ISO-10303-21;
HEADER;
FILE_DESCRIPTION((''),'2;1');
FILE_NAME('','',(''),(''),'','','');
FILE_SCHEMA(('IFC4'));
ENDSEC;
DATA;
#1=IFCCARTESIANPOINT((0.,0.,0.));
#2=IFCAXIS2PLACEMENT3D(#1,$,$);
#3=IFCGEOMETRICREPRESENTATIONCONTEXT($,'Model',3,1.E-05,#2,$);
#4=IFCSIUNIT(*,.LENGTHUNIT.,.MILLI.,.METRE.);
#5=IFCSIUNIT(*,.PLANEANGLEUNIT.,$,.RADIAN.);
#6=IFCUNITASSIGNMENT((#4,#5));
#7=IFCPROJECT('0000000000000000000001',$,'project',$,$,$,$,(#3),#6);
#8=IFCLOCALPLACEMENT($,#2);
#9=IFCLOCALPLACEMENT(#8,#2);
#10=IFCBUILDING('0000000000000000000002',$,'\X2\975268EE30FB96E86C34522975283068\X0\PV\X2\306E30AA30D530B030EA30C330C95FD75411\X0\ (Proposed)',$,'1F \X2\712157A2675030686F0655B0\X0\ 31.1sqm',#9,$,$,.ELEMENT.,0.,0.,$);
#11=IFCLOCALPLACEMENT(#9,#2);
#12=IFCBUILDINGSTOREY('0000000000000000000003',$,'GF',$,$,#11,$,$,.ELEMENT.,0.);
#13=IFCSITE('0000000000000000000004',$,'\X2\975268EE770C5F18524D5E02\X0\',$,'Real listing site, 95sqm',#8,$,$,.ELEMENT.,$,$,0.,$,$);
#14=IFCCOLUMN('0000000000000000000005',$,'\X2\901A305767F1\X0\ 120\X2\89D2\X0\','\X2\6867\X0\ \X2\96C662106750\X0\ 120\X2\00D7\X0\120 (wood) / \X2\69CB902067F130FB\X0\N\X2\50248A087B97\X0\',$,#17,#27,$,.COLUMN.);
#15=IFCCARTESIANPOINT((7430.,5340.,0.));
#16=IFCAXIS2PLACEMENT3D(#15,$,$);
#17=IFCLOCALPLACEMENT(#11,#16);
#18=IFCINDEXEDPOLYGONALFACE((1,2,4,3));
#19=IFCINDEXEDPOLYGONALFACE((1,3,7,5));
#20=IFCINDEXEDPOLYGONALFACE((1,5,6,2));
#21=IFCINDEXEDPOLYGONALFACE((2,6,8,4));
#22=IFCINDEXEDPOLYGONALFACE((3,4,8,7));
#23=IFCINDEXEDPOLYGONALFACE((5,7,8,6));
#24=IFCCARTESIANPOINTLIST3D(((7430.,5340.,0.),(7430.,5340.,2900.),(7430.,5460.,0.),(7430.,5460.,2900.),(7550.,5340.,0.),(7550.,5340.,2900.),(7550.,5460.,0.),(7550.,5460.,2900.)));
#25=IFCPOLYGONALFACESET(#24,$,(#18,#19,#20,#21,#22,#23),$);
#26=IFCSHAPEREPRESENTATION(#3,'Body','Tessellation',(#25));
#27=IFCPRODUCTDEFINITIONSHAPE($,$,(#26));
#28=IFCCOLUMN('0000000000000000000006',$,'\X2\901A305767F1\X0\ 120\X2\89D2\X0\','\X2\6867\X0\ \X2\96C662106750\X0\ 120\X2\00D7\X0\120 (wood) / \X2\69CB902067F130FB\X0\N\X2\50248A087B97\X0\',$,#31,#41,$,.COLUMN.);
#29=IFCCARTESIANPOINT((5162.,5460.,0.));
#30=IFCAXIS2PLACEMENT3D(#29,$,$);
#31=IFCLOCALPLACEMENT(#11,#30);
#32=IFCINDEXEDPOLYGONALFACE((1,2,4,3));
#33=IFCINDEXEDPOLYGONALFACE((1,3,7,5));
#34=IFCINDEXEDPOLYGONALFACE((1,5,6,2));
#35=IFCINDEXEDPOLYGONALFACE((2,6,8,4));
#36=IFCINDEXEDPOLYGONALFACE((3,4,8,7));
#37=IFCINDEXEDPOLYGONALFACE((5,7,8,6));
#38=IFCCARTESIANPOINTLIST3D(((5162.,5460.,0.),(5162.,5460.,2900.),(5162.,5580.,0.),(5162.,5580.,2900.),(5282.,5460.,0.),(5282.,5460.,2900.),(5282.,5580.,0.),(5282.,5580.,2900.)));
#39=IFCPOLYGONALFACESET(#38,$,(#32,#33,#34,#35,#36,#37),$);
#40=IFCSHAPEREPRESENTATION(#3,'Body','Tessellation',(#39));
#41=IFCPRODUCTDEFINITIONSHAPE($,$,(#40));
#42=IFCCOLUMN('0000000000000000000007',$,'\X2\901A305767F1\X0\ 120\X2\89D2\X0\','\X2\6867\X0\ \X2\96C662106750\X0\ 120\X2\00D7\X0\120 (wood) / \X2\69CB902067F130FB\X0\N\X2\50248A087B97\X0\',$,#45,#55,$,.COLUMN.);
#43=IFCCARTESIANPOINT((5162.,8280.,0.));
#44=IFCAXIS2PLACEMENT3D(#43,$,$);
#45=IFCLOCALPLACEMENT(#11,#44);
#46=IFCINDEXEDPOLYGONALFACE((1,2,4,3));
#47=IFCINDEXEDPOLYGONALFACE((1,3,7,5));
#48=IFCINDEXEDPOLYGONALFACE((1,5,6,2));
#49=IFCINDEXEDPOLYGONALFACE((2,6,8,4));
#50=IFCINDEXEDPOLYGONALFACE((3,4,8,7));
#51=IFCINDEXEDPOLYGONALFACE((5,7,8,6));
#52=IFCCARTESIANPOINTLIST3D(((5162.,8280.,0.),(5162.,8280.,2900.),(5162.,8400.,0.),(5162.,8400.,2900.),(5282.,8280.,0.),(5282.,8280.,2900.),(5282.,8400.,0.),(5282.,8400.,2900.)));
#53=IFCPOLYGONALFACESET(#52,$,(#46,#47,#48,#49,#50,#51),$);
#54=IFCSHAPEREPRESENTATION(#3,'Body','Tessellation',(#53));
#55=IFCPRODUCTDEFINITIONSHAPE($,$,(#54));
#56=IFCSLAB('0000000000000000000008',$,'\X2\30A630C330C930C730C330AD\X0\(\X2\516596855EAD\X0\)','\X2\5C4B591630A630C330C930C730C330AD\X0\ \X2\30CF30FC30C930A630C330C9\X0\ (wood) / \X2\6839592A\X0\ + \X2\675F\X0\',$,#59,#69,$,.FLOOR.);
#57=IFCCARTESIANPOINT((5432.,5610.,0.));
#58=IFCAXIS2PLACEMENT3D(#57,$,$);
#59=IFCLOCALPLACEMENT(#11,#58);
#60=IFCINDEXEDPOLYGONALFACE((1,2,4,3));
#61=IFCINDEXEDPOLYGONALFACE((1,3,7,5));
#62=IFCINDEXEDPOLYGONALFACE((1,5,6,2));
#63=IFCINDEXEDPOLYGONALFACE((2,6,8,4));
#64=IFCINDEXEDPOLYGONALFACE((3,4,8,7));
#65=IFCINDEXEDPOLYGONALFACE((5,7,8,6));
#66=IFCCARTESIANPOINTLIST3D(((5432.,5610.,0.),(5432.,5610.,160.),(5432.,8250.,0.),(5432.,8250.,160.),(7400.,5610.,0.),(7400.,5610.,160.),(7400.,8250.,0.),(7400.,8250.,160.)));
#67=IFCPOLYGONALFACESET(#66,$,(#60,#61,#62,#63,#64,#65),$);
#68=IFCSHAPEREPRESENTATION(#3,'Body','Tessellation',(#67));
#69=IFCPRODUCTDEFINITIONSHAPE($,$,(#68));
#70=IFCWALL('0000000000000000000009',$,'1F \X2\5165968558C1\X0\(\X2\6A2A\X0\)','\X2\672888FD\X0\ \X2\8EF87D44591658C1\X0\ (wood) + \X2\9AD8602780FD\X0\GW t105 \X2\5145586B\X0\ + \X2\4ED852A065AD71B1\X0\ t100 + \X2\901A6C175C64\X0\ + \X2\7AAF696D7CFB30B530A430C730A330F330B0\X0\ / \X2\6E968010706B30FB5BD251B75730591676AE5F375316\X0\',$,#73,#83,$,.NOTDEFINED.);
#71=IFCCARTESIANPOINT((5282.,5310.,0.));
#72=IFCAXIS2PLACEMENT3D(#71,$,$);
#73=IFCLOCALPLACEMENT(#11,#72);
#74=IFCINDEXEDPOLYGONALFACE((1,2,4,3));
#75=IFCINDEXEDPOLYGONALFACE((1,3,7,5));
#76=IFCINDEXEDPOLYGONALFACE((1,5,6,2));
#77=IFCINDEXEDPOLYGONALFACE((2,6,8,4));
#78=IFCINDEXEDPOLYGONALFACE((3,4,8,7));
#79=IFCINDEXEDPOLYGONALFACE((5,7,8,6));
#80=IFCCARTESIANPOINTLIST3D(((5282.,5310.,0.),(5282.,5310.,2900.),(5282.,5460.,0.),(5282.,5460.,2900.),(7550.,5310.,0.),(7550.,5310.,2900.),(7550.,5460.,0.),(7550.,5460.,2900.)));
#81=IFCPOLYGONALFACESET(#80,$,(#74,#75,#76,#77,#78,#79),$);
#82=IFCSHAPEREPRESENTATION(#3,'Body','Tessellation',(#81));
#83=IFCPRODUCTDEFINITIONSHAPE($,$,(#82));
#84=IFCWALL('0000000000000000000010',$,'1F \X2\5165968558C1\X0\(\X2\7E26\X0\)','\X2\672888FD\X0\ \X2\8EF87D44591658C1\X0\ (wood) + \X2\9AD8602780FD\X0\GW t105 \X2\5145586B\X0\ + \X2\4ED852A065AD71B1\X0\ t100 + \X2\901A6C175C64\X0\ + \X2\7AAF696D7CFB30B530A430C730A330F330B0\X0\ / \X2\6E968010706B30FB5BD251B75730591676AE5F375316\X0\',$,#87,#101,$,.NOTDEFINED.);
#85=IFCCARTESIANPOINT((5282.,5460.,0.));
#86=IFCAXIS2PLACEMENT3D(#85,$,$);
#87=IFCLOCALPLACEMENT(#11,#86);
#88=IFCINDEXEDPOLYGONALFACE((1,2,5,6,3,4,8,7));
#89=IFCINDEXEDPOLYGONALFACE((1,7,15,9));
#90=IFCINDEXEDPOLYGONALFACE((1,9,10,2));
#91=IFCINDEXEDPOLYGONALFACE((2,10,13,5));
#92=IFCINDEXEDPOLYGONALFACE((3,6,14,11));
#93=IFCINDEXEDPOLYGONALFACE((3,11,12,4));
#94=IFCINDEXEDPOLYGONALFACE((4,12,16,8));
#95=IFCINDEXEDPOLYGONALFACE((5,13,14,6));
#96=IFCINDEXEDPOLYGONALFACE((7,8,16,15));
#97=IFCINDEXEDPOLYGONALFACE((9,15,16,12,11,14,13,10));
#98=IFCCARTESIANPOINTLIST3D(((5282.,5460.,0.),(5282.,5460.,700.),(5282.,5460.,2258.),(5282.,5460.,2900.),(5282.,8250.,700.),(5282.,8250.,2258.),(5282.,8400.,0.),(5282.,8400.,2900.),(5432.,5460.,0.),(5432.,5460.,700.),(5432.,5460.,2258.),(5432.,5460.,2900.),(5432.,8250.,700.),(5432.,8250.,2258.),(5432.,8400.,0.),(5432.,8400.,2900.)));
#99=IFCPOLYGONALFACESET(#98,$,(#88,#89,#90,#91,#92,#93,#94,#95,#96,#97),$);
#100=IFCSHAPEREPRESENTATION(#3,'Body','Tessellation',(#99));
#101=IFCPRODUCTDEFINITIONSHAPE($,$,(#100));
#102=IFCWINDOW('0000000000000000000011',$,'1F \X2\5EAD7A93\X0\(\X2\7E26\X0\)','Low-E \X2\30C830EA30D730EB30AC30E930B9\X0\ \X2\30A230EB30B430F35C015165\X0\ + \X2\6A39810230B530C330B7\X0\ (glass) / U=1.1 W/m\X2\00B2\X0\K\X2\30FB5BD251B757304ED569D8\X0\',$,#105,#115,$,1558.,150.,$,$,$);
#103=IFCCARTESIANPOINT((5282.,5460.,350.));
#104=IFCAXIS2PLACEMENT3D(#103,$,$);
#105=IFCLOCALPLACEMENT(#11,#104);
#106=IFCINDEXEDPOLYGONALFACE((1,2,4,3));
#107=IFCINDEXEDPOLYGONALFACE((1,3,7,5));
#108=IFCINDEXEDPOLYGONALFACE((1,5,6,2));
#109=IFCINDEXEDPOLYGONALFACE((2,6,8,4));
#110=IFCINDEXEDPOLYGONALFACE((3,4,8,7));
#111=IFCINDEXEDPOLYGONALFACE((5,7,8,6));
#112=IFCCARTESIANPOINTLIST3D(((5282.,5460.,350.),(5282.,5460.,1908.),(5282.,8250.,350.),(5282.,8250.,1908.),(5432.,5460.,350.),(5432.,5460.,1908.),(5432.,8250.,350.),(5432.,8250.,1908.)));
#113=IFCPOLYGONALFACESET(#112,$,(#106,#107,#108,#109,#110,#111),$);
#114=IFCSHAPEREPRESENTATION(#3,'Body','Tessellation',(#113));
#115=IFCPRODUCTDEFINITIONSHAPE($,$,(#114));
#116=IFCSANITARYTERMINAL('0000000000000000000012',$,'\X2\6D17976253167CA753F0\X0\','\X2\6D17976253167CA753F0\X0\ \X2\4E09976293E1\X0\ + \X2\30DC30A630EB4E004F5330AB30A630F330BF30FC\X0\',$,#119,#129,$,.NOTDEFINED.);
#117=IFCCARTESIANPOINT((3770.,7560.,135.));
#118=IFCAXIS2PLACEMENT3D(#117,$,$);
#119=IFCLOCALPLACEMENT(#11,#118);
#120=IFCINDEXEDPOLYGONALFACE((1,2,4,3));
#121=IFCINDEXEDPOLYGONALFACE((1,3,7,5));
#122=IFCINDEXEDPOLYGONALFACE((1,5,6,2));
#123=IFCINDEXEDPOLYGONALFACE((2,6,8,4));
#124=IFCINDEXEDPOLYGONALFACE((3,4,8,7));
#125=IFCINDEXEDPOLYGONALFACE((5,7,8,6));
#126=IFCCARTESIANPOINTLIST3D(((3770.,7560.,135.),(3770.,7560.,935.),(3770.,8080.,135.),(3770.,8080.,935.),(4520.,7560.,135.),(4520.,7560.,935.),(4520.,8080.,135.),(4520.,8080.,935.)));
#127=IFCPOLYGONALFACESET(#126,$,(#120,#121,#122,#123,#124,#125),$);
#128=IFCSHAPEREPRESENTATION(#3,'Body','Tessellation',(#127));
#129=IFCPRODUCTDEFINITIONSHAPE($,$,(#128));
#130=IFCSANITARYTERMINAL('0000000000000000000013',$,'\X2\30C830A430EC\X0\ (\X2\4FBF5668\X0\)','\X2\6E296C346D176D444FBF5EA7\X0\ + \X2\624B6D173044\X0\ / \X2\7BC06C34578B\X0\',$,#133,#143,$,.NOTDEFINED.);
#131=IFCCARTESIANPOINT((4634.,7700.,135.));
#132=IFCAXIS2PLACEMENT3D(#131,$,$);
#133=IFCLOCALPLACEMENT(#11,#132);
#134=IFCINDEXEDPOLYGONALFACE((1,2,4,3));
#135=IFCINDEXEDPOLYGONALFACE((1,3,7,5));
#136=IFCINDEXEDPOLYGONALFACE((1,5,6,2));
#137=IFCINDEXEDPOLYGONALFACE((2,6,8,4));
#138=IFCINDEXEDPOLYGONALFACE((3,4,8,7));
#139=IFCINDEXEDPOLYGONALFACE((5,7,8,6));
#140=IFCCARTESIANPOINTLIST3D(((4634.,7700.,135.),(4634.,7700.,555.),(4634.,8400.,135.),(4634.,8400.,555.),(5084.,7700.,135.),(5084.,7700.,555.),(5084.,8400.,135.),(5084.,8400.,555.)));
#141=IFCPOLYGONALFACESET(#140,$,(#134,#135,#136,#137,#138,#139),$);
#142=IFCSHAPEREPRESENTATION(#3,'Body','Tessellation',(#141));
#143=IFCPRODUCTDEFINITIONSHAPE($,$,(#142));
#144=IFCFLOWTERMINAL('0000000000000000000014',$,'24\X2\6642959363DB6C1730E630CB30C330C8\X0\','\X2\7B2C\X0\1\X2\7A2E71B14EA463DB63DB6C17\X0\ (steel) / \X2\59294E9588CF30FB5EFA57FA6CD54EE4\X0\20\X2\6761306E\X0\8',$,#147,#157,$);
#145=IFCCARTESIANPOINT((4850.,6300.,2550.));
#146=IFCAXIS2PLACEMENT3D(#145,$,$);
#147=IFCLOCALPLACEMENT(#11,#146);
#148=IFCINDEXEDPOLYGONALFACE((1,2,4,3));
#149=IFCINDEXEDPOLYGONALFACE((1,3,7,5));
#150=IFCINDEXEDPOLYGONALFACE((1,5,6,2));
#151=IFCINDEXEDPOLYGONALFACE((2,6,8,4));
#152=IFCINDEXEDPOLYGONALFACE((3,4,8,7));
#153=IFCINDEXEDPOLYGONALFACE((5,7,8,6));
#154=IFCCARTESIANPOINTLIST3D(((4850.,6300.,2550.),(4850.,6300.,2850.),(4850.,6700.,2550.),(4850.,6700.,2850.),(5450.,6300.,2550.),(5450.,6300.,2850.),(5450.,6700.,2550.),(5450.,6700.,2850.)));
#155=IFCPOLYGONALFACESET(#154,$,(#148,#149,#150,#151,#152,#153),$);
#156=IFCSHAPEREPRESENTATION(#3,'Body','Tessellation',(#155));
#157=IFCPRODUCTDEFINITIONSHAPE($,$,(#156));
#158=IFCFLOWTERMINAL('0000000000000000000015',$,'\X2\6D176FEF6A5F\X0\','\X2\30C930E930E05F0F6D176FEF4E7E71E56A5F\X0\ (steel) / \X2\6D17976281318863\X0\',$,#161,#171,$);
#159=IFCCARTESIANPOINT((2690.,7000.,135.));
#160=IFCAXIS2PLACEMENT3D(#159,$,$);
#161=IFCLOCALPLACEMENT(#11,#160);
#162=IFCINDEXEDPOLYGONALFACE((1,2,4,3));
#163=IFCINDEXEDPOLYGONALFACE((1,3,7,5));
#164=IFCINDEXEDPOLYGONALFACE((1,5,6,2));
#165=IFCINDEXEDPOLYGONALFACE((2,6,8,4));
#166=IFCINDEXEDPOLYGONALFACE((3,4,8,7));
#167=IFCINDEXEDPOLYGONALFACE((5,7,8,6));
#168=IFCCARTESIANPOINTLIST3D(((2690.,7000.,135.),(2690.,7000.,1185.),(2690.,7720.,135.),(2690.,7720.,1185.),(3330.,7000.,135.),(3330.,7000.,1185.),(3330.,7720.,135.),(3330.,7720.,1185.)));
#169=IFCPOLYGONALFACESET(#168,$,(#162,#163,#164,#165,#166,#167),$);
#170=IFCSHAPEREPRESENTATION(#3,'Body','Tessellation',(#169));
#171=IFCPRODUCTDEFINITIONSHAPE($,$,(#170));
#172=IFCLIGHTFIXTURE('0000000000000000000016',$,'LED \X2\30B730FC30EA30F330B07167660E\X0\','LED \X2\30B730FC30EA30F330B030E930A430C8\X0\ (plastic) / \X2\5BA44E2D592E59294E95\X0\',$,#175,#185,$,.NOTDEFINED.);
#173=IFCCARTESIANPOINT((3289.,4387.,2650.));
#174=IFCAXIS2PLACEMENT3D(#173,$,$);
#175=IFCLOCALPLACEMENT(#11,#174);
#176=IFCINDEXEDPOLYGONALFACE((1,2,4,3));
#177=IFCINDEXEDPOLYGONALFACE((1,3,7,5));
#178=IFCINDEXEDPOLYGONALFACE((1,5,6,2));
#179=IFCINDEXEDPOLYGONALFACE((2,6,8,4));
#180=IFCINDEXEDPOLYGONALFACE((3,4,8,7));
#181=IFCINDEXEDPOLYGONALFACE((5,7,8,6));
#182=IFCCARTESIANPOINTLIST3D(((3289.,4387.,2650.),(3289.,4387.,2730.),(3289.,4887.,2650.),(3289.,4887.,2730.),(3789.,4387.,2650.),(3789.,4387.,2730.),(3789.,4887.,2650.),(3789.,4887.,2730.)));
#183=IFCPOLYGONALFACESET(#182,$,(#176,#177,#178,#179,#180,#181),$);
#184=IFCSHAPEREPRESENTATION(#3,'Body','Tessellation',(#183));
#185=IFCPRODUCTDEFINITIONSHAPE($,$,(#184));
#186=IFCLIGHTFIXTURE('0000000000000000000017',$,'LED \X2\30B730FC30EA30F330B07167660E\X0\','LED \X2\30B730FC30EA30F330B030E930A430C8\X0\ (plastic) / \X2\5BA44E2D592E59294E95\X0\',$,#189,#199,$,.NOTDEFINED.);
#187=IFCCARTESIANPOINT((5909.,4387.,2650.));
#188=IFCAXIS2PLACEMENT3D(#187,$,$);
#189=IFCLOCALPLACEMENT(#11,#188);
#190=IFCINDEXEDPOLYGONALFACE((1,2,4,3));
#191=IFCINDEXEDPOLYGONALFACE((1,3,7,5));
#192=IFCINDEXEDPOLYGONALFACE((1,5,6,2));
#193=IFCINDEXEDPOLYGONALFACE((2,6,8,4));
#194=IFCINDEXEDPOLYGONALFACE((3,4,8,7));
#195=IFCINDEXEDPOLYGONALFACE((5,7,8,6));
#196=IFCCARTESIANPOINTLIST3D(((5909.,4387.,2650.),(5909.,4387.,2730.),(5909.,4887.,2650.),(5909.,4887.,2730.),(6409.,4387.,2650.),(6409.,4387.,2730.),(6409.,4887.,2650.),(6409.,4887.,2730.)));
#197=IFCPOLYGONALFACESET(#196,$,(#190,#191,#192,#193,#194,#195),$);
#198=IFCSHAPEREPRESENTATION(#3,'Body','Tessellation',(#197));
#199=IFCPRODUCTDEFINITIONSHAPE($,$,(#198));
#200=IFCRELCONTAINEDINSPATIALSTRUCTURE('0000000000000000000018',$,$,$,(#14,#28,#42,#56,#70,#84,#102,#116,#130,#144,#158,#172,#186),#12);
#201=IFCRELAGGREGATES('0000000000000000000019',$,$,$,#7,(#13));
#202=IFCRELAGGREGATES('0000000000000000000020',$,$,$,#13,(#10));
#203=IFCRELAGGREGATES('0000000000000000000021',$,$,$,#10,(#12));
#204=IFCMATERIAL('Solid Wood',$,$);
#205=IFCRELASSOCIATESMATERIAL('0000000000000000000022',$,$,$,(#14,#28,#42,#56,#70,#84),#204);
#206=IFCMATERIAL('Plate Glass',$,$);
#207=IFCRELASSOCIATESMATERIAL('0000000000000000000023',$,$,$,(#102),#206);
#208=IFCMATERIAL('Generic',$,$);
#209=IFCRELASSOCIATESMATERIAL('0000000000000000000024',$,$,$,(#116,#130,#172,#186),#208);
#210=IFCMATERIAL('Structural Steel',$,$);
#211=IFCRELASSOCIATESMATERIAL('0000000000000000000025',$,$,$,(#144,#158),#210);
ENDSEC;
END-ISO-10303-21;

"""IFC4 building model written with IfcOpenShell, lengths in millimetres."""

from ifc_helpers import new_model, si_unit, frame, frame_2d, origin, place, context, project, spatial, rectangle, extrude, material, element, fill, save


model = new_model("IFC4")

# Units and contexts
model_context = context("Model", 3, precision=1e-05, world=origin())
ifc_project = project(units=[si_unit("LENGTHUNIT", "METRE", prefix="MILLI"), si_unit("PLANEANGLEUNIT", "RADIAN")], contexts=[model_context])

# Site, building, storey
site_placement = place(None, origin())
site = spatial("IfcSite", under=ifc_project, at=site_placement, Name="青森県弘前市", ObjectType="Real listing site, 95sqm", CompositionType="ELEMENT", RefElevation=0.0)
building_placement = place(site_placement, origin())
building = spatial("IfcBuilding", under=site, at=building_placement, Name="青森・雨水利用とPVのオフグリッド志向 (Proposed)", ObjectType="1F 無垢材と漆喰 31.1sqm", CompositionType="ELEMENT", ElevationOfRefHeight=0.0, ElevationOfTerrain=0.0)
storey_placement = place(building_placement, origin())
storey = spatial("IfcBuildingStorey", under=building, at=storey_placement, Name="GF", CompositionType="ELEMENT", Elevation=0.0)

# Columns
ifc_material_1 = material(Name="Solid Wood")
column_1_placement = place(storey_placement, frame((7430.0, 5340.0, 0.0)))
element("IfcColumn", 1, at=column_1_placement, inside=storey, material=ifc_material_1, Name="通し柱 120角", Description="桧 集成材 120×120 (wood) / 構造柱・N値計算", PredefinedType="COLUMN", context=model_context, shape_type="SweptSolid", body=[
    extrude(rectangle(XDim=120.0, YDim=120.0, at=frame_2d((60.0, 60.0))), frame((7430.0, 5340.0, 0.0)), (0.0, 0.0, 1.0), 2900.0),
])
column_2_placement = place(storey_placement, frame((5162.0, 5460.0, 0.0)))
element("IfcColumn", 2, at=column_2_placement, inside=storey, material=ifc_material_1, Name="通し柱 120角", Description="桧 集成材 120×120 (wood) / 構造柱・N値計算", PredefinedType="COLUMN", context=model_context, shape_type="SweptSolid", body=[
    extrude(rectangle(XDim=120.0, YDim=120.0, at=frame_2d((60.0, 60.0))), frame((5162.0, 5460.0, 0.0)), (0.0, 0.0, 1.0), 2900.0),
])
column_3_placement = place(storey_placement, frame((5162.0, 8280.0, 0.0)))
element("IfcColumn", 3, at=column_3_placement, inside=storey, material=ifc_material_1, Name="通し柱 120角", Description="桧 集成材 120×120 (wood) / 構造柱・N値計算", PredefinedType="COLUMN", context=model_context, shape_type="SweptSolid", body=[
    extrude(rectangle(XDim=120.0, YDim=120.0, at=frame_2d((60.0, 60.0))), frame((5162.0, 8280.0, 0.0)), (0.0, 0.0, 1.0), 2900.0),
])

# Slab
slab_placement = place(storey_placement, frame((5432.0, 5610.0, 0.0)))
element("IfcSlab", 4, at=slab_placement, inside=storey, material=ifc_material_1, Name="ウッドデッキ(入隅庭)", Description="屋外ウッドデッキ ハードウッド (wood) / 根太 + 束", PredefinedType="FLOOR", context=model_context, shape_type="SweptSolid", body=[
    extrude(rectangle(XDim=1968.0, YDim=2640.0, at=frame_2d((984.0, 1320.0))), frame((5432.0, 5610.0, 0.0)), (0.0, 0.0, 1.0), 160.0),
])

# Wall
wall_1_placement = place(storey_placement, frame((5282.0, 5310.0, 0.0)))
element("IfcWall", 5, at=wall_1_placement, inside=storey, material=ifc_material_1, Name="1F 入隅壁(横)", Description="木製 軸組外壁 (wood) + 高性能GW t105 充填 + 付加断熱 t100 + 通気層 + 窯業系サイディング / 準耐火・寒冷地外皮強化", PredefinedType="NOTDEFINED", context=model_context, shape_type="SweptSolid", body=[
    extrude(rectangle(XDim=2268.0, YDim=150.0, at=frame_2d((1134.0, 75.0))), frame((5282.0, 5310.0, 0.0)), (0.0, 0.0, 1.0), 2900.0),
])

# Wall, opening, window
wall_2_placement = place(storey_placement, frame((5282.0, 5460.0, 0.0)))
wall_2 = element("IfcWall", 6, at=wall_2_placement, inside=storey, material=ifc_material_1, Name="1F 入隅壁(縦)", Description="木製 軸組外壁 (wood) + 高性能GW t105 充填 + 付加断熱 t100 + 通気層 + 窯業系サイディング / 準耐火・寒冷地外皮強化", PredefinedType="NOTDEFINED", context=model_context, shape_type="SweptSolid", body=[
    extrude(rectangle(XDim=150.0, YDim=2940.0, at=frame_2d((75.0, 1470.0))), frame((5282.0, 5460.0, 0.0)), (0.0, 0.0, 1.0), 2900.0),
])
opening_placement = place(storey_placement, frame((5282.0, 5460.0, 350.0)))
opening = element("IfcOpeningElement", 7, at=opening_placement, cuts=wall_2, PredefinedType="NOTDEFINED", context=model_context, shape_type="SweptSolid", body=[
    extrude(rectangle(XDim=150.0, YDim=2790.0, at=frame_2d((75.0, 1395.0))), frame((5282.0, 5460.0, 350.0)), (0.0, 0.0, 1.0), 1558.0),
])
ifc_material_2 = material(Name="Plate Glass")
window_placement = place(storey_placement, frame((5282.0, 5460.0, 350.0)))
window = element("IfcWindow", 8, at=window_placement, inside=storey, material=ifc_material_2, Name="1F 庭窓(縦)", Description="Low-E トリプルガラス アルゴン封入 + 樹脂サッシ (glass) / U=1.1 W/m²K・寒冷地仕様", OverallHeight=1558.0, OverallWidth=150.0, context=model_context, shape_type="SweptSolid", body=[
    extrude(rectangle(XDim=150.0, YDim=2790.0, at=frame_2d((75.0, 1395.0))), frame((5282.0, 5460.0, 350.0)), (0.0, 0.0, 1.0), 1558.0),
])
fill(opening, window)

# Sanitary terminals
ifc_material_3 = material(Name="Generic")
sanitary_terminal_1_placement = place(storey_placement, frame((3770.0, 7560.0, 135.0)))
element("IfcSanitaryTerminal", 9, at=sanitary_terminal_1_placement, inside=storey, material=ifc_material_3, Name="洗面化粧台", Description="洗面化粧台 三面鏡 + ボウル一体カウンター", PredefinedType="NOTDEFINED", context=model_context, shape_type="SweptSolid", body=[
    extrude(rectangle(XDim=750.0, YDim=520.0, at=frame_2d((375.0, 260.0))), frame((3770.0, 7560.0, 135.0)), (0.0, 0.0, 1.0), 800.0),
])
sanitary_terminal_2_placement = place(storey_placement, frame((4634.0, 7700.0, 135.0)))
element("IfcSanitaryTerminal", 10, at=sanitary_terminal_2_placement, inside=storey, material=ifc_material_3, Name="トイレ (便器)", Description="温水洗浄便座 + 手洗い / 節水型", PredefinedType="NOTDEFINED", context=model_context, shape_type="SweptSolid", body=[
    extrude(rectangle(XDim=450.0, YDim=700.0, at=frame_2d((225.0, 350.0))), frame((4634.0, 7700.0, 135.0)), (0.0, 0.0, 1.0), 420.0),
])

# Flow terminals
ifc_material_4 = material(Name="Structural Steel")
flow_terminal_1_placement = place(storey_placement, frame((4850.0, 6300.0, 2550.0)))
element("IfcFlowTerminal", 11, at=flow_terminal_1_placement, inside=storey, material=ifc_material_4, Name="24時間換気ユニット", Description="第1種熱交換換気 (steel) / 天井裏・建基法令20条の8", context=model_context, shape_type="SweptSolid", body=[
    extrude(rectangle(XDim=600.0, YDim=400.0, at=frame_2d((300.0, 200.0))), frame((4850.0, 6300.0, 2550.0)), (0.0, 0.0, 1.0), 300.0),
])
flow_terminal_2_placement = place(storey_placement, frame((2690.0, 7000.0, 135.0)))
element("IfcFlowTerminal", 12, at=flow_terminal_2_placement, inside=storey, material=ifc_material_4, Name="洗濯機", Description="ドラム式洗濯乾燥機 (steel) / 洗面脱衣", context=model_context, shape_type="SweptSolid", body=[
    extrude(rectangle(XDim=640.0, YDim=720.0, at=frame_2d((320.0, 360.0))), frame((2690.0, 7000.0, 135.0)), (0.0, 0.0, 1.0), 1050.0),
])

# Light fixtures
light_fixture_1_placement = place(storey_placement, frame((3289.0, 4387.0, 2650.0)))
element("IfcLightFixture", 13, at=light_fixture_1_placement, inside=storey, material=ifc_material_3, Name="LED シーリング照明", Description="LED シーリングライト (plastic) / 室中央天井", PredefinedType="NOTDEFINED", context=model_context, shape_type="SweptSolid", body=[
    extrude(rectangle(XDim=500.0, YDim=500.0, at=frame_2d((250.0, 250.0))), frame((3289.0, 4387.0, 2650.0)), (0.0, 0.0, 1.0), 80.0),
])
light_fixture_2_placement = place(storey_placement, frame((5909.0, 4387.0, 2650.0)))
element("IfcLightFixture", 14, at=light_fixture_2_placement, inside=storey, material=ifc_material_3, Name="LED シーリング照明", Description="LED シーリングライト (plastic) / 室中央天井", PredefinedType="NOTDEFINED", context=model_context, shape_type="SweptSolid", body=[
    extrude(rectangle(XDim=500.0, YDim=500.0, at=frame_2d((250.0, 250.0))), frame((5909.0, 4387.0, 2650.0)), (0.0, 0.0, 1.0), 80.0),
])

save(model, "model.ifc")
